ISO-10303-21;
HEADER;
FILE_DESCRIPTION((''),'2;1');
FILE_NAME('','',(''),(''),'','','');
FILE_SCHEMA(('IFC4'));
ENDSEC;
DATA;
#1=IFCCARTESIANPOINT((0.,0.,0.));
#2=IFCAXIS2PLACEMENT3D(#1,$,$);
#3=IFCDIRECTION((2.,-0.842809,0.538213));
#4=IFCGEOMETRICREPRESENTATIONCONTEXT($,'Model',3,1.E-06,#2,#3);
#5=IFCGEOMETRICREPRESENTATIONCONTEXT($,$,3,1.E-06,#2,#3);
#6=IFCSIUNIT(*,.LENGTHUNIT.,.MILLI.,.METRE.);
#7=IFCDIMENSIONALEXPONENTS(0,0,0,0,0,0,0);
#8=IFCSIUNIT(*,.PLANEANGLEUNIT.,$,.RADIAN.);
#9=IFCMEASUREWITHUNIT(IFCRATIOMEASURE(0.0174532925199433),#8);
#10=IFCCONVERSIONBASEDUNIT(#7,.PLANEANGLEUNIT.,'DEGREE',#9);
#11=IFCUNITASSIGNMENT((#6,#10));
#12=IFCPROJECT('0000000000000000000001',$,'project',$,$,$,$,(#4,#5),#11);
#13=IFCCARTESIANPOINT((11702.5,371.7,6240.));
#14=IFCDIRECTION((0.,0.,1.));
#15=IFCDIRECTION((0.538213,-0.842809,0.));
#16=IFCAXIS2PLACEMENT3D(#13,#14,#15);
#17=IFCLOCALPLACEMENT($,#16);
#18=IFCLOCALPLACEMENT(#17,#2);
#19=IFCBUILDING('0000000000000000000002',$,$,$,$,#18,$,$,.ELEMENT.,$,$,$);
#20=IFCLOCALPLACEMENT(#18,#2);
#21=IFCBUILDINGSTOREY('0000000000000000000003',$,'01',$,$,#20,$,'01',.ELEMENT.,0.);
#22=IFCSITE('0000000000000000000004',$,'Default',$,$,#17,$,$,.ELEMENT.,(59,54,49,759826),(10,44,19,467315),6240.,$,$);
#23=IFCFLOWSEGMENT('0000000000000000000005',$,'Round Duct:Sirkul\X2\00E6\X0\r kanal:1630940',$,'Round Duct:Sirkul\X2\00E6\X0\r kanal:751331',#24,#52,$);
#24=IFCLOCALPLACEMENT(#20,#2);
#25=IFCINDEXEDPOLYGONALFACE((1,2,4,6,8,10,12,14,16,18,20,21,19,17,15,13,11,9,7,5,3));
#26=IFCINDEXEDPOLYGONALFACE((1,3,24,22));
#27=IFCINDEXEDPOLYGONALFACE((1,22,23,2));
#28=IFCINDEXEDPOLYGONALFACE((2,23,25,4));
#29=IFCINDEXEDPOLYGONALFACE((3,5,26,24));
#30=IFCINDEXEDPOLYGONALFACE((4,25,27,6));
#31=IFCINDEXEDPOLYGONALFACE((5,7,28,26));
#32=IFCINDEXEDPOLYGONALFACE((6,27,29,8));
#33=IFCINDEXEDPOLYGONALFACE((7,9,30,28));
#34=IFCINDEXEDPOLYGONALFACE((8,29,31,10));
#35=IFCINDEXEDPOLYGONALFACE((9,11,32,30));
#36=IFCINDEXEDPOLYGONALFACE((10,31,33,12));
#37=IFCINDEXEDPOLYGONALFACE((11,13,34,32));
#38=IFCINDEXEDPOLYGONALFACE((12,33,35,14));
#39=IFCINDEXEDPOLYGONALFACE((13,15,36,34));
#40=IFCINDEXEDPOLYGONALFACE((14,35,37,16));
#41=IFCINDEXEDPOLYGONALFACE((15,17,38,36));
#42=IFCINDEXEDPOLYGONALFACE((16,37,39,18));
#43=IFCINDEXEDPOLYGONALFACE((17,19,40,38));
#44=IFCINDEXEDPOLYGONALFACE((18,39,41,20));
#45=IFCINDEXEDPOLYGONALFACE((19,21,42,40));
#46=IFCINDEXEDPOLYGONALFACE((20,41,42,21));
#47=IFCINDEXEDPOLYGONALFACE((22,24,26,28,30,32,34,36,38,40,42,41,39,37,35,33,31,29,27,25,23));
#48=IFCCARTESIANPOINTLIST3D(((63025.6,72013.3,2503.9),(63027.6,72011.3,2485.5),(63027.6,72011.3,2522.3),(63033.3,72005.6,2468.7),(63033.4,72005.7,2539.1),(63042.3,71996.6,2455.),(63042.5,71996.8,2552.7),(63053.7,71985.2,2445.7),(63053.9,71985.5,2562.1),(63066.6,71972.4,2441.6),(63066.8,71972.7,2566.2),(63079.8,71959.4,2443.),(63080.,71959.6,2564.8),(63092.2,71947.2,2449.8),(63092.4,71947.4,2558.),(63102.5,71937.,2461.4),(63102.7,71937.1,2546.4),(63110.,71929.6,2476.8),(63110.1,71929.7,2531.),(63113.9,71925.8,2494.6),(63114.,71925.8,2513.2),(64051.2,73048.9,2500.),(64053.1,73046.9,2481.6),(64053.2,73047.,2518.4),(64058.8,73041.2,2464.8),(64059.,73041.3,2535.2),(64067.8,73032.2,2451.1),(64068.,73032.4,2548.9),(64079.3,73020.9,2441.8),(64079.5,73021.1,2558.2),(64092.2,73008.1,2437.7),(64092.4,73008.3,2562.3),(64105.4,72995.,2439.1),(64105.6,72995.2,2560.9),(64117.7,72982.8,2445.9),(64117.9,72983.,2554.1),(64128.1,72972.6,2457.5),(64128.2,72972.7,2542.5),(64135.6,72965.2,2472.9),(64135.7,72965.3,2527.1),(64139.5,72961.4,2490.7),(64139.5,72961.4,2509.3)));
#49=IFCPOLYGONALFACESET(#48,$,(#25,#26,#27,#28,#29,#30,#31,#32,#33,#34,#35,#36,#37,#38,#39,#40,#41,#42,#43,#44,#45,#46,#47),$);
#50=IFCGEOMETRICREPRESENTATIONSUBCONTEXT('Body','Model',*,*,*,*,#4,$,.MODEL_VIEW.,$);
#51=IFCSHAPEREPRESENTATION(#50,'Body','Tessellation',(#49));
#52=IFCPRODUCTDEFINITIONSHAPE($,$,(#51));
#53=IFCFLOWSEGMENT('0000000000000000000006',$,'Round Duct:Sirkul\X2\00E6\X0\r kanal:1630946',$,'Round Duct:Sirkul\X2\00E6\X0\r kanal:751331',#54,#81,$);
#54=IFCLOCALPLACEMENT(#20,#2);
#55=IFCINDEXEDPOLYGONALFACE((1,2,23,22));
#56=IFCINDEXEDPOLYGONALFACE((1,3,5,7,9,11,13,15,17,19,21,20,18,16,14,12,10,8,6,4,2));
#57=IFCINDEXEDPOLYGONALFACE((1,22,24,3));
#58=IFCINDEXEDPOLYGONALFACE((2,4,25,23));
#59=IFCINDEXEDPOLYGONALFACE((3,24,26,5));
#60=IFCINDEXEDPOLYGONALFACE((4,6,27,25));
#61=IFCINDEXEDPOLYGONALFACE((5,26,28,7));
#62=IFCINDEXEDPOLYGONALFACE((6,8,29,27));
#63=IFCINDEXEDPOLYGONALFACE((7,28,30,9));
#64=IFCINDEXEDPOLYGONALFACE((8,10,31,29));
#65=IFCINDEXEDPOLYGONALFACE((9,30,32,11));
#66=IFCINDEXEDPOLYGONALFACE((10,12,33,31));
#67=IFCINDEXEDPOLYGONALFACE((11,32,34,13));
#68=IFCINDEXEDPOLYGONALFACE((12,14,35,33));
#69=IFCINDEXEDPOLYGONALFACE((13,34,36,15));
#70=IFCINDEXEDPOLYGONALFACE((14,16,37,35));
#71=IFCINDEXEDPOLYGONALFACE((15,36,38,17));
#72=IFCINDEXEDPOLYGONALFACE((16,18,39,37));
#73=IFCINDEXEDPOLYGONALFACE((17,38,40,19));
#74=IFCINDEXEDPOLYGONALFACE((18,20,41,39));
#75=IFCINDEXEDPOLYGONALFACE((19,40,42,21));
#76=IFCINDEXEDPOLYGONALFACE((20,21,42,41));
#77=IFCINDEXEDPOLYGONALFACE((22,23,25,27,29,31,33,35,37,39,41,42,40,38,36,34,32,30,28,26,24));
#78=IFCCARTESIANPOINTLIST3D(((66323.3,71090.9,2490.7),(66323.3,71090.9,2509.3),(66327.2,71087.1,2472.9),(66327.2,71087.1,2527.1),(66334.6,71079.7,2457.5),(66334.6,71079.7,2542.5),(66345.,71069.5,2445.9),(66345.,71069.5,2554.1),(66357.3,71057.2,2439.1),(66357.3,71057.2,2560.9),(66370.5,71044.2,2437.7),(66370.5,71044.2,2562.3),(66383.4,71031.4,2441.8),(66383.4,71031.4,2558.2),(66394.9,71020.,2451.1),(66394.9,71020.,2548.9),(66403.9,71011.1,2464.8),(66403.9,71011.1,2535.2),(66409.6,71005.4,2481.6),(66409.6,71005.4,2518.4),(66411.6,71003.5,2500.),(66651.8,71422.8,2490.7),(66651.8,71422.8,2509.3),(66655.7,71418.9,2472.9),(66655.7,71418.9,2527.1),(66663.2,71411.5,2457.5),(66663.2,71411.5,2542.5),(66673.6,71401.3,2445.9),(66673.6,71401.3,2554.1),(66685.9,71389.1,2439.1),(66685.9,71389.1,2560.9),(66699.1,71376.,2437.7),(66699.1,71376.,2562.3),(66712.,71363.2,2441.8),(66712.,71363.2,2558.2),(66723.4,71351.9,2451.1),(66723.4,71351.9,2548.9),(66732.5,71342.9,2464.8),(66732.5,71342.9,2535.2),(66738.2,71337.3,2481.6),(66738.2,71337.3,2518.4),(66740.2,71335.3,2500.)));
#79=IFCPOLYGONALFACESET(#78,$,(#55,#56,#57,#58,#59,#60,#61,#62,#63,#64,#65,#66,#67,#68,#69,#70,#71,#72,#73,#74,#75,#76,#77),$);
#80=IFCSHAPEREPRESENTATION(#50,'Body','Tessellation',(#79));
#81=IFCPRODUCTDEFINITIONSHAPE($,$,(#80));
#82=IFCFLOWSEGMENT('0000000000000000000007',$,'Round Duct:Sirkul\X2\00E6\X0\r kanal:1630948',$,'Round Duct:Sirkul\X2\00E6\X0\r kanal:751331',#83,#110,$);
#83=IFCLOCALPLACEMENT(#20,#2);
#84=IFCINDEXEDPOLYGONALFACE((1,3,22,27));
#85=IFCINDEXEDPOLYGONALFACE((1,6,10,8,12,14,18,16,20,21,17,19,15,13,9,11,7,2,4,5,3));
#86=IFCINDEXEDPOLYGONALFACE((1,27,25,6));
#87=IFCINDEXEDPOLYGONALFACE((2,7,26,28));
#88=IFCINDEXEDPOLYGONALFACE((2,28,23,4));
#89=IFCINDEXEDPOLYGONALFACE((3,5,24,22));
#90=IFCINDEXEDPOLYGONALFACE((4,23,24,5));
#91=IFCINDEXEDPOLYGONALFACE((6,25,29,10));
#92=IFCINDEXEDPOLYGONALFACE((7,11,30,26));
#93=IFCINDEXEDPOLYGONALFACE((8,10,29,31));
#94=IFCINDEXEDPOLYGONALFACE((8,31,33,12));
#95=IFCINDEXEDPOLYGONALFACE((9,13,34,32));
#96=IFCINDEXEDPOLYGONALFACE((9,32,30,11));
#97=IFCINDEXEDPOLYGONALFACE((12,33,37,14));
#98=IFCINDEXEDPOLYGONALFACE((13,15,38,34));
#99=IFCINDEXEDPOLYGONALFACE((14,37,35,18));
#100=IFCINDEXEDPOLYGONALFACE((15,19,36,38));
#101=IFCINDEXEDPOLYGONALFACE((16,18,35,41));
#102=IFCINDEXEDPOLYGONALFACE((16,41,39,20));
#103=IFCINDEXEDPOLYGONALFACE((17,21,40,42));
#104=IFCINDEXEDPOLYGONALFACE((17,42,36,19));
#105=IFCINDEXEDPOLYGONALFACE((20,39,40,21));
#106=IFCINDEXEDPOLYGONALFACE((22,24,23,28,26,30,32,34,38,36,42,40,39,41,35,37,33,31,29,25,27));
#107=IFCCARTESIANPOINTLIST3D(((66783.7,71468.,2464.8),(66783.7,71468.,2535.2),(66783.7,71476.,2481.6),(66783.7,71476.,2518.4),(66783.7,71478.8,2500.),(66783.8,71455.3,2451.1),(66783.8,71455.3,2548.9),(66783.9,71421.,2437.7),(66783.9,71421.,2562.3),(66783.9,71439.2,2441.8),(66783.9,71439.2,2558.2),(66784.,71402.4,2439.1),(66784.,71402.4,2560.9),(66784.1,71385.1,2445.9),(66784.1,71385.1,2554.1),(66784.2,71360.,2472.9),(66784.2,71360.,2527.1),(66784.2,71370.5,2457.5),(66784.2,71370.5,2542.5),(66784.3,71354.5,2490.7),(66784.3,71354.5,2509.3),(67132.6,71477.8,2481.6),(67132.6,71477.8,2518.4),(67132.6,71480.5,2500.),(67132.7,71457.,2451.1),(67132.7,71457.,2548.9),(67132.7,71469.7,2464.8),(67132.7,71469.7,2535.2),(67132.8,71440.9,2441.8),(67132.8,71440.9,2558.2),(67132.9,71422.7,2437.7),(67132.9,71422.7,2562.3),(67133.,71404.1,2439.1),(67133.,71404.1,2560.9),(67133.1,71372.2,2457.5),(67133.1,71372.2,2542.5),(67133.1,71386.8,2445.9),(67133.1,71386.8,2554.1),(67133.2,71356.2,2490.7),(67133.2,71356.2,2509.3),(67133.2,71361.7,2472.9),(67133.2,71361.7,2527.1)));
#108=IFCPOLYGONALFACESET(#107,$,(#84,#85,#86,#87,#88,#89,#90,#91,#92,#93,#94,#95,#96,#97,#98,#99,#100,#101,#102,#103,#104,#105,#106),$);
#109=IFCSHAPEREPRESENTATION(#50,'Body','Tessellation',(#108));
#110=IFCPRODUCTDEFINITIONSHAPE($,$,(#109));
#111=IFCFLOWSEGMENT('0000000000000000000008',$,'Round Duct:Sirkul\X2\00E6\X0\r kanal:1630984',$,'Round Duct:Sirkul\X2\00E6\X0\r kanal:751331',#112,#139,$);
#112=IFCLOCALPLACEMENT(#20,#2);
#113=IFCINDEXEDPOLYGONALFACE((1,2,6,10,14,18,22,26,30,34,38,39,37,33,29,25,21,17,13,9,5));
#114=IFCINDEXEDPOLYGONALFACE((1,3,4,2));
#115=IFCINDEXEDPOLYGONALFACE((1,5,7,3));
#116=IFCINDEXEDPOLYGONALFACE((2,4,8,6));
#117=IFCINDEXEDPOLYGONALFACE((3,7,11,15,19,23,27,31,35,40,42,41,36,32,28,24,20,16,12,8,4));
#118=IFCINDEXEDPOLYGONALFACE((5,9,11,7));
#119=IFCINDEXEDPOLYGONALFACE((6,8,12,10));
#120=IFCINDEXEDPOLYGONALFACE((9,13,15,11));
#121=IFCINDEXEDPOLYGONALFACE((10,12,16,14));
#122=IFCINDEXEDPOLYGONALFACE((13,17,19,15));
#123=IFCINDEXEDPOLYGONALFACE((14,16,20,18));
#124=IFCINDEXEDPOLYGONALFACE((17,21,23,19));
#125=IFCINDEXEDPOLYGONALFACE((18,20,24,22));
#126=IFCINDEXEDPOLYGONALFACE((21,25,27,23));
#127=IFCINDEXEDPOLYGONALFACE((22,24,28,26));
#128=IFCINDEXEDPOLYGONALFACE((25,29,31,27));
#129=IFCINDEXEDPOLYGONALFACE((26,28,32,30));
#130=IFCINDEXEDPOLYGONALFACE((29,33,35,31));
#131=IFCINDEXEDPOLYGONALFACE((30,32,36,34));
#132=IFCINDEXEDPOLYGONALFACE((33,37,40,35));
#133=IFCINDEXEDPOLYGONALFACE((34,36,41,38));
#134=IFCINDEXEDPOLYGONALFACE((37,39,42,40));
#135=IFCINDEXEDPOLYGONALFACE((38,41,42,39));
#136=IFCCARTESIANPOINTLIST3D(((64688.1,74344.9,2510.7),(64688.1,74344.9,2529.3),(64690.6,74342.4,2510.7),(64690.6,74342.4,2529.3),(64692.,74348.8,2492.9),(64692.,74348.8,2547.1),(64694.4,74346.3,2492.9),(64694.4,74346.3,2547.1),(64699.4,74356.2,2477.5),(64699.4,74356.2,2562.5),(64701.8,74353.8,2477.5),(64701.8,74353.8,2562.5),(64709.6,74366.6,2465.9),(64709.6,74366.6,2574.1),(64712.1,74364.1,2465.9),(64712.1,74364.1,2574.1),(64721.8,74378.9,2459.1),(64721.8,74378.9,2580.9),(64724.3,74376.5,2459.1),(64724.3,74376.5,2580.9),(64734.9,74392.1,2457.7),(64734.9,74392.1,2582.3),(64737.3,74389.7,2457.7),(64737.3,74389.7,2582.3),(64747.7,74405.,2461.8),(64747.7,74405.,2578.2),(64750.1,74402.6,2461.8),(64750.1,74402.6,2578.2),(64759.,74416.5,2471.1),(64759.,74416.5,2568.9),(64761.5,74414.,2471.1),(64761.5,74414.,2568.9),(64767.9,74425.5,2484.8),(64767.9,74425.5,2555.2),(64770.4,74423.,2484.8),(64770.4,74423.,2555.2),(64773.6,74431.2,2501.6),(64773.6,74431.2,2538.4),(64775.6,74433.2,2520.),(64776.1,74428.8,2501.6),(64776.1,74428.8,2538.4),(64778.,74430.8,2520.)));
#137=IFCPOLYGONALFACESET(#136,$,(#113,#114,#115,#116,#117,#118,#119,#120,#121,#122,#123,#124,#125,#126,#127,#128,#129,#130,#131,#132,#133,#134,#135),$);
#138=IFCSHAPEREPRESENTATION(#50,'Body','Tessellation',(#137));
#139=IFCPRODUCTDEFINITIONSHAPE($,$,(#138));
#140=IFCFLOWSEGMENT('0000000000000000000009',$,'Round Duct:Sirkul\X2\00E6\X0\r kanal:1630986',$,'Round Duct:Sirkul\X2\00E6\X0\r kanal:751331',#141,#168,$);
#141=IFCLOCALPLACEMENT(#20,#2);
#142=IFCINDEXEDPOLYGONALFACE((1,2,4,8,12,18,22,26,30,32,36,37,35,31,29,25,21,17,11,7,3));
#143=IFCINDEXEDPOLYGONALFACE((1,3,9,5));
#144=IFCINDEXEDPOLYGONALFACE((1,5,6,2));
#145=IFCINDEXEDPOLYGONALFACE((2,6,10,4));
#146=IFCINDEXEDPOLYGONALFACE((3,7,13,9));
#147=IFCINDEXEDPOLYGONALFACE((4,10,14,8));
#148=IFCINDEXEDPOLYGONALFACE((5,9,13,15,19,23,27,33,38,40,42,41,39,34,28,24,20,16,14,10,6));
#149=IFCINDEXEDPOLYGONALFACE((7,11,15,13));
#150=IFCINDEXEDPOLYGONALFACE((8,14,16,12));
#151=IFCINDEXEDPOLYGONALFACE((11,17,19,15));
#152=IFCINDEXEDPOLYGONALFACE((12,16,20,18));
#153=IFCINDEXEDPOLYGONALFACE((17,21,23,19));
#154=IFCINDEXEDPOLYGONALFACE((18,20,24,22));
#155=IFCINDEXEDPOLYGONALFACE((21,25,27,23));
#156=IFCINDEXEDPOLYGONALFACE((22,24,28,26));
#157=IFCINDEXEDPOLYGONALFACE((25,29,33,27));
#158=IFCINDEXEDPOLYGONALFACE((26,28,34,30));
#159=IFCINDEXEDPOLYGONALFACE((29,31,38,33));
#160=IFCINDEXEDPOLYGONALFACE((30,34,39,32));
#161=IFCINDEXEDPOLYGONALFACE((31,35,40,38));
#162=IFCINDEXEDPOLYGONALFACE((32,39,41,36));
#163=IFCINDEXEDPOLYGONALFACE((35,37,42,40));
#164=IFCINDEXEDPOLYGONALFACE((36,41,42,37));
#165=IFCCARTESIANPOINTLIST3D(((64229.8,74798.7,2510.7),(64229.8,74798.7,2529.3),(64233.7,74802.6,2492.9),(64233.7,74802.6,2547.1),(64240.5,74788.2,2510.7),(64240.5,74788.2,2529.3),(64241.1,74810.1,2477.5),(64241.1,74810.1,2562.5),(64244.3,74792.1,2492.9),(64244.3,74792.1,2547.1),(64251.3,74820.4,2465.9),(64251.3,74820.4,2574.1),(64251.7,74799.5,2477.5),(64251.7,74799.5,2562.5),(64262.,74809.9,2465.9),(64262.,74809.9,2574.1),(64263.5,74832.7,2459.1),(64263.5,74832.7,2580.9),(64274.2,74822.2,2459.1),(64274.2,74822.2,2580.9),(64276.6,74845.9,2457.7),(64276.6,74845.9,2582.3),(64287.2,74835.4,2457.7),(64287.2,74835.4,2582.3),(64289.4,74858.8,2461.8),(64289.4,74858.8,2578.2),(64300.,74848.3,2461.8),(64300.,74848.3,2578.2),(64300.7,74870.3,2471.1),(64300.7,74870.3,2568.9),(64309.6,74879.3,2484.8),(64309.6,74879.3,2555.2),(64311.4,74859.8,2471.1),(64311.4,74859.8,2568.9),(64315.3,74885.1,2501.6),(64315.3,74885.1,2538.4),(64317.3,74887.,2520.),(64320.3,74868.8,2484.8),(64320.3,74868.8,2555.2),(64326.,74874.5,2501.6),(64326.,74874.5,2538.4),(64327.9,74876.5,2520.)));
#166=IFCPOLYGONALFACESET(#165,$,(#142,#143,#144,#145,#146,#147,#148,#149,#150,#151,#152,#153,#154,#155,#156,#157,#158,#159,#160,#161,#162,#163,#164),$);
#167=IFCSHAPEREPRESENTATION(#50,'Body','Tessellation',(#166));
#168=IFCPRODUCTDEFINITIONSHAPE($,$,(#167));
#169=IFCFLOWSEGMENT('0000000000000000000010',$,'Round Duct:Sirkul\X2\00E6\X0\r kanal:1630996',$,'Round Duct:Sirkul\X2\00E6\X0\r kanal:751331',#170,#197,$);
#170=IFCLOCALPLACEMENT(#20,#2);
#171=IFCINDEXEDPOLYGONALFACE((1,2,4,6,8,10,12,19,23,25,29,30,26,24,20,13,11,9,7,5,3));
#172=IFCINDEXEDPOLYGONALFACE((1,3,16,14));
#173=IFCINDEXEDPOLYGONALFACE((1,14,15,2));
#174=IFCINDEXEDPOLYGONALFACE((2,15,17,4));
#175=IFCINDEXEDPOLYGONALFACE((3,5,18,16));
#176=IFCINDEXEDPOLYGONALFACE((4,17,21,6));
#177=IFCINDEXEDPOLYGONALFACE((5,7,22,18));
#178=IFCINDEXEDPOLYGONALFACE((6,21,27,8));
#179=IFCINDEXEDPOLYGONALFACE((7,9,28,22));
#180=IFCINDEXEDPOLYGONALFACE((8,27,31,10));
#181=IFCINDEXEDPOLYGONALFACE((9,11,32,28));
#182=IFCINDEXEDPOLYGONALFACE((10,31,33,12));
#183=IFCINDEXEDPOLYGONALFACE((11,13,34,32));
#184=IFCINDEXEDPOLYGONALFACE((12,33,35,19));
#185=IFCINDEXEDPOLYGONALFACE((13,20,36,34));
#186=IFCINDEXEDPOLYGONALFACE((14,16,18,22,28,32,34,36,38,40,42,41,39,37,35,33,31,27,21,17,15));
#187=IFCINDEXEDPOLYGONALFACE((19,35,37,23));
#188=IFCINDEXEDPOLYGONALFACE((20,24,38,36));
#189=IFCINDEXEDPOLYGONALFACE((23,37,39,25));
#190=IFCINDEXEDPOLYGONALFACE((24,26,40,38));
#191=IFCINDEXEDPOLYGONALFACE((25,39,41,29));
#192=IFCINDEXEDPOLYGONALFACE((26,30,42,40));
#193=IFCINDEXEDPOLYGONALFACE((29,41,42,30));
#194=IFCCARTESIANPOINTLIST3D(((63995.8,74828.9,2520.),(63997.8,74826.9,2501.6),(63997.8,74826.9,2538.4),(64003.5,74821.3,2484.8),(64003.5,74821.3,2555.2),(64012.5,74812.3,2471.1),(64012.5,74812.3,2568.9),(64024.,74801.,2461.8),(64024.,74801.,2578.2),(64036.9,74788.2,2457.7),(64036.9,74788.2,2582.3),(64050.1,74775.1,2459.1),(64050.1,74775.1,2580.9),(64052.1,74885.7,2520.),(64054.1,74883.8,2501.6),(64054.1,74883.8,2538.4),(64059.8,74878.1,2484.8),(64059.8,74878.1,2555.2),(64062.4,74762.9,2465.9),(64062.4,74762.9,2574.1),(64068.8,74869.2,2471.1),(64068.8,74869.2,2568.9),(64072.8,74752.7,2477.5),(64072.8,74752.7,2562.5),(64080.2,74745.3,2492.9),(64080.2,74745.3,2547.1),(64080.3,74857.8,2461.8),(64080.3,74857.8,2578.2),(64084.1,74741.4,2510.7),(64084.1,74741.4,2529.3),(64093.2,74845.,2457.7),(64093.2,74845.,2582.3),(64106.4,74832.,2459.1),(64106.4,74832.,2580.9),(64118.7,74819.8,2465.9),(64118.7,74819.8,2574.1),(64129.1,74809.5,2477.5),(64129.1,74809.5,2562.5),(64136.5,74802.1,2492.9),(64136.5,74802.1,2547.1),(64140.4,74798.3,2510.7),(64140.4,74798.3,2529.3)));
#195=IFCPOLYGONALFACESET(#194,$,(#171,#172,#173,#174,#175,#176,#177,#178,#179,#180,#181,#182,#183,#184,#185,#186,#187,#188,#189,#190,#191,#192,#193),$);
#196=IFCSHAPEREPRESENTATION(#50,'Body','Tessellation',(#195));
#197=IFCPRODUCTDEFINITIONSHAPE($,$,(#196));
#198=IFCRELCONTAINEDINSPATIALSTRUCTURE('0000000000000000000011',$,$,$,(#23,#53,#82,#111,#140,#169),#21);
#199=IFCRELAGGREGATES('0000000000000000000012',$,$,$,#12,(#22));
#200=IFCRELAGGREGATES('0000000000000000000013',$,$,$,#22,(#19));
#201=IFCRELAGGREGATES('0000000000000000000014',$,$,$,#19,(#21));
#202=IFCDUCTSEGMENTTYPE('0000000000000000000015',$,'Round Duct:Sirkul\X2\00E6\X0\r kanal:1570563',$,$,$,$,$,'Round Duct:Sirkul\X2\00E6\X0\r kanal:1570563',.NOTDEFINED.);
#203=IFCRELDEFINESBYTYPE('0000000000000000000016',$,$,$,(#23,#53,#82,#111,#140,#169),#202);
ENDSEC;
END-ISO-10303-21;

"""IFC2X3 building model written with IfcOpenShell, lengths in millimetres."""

from ifc_helpers import new_model, entity, si_unit, converted_unit, direction, frame, frame_2d, origin, origin_2d_with_axis, place, context, subcontext, project, spatial, circle, extrude, type_object, element, save


model = new_model("IFC2X3")

# Units and contexts
model_context = context("Model", 3, precision=1e-06, world=origin(), true_north=direction((2.0, -0.842809, 0.538213)))
context_of_model = context(None, 3, precision=1e-06, world=origin(), true_north=direction((2.0, -0.842809, 0.538213)))
body_context = subcontext(model_context, "Body", "Model", "MODEL_VIEW")
ifc_project = project(units=[si_unit("LENGTHUNIT", "METRE", prefix="MILLI"), converted_unit("PLANEANGLEUNIT", "DEGREE", entity("IfcRatioMeasure", 0.0174532925199433), si_unit("PLANEANGLEUNIT", "RADIAN"), dimensions=[0, 0, 0, 0, 0, 0, 0])], contexts=[model_context, context_of_model])

# Site, building, storey
site_placement = place(None, frame((11702.5, 371.7, 6240.0), z_axis=(0.0, 0.0, 1.0), x_axis=(0.538213, -0.842809, 0.0)))
site = spatial("IfcSite", under=ifc_project, at=site_placement, Name="Default", CompositionType="ELEMENT", RefLatitude=(59, 54, 49, 759826), RefLongitude=(10, 44, 19, 467315), RefElevation=6240.0)
building_placement = place(site_placement, origin())
building = spatial("IfcBuilding", under=site, at=building_placement, CompositionType="ELEMENT")
storey_placement = place(building_placement, origin())
storey = spatial("IfcBuildingStorey", under=building, at=storey_placement, Name="01", LongName="01", CompositionType="ELEMENT", Elevation=0.0)

# Flow segments
duct_segment_type = type_object("IfcDuctSegmentType", Name="Round Duct:Sirkulær kanal:1570563", ElementType="Round Duct:Sirkulær kanal:1570563", PredefinedType="NOTDEFINED")
flow_segment_1_placement = place(storey_placement, origin())
element("IfcFlowSegment", 1, at=flow_segment_1_placement, inside=storey, type_object=duct_segment_type, Name="Round Duct:Sirkulær kanal:1630940", ObjectType="Round Duct:Sirkulær kanal:751331", context=body_context, shape_type="SweptSolid", body=[
    extrude(circle(Radius=62.5, at=origin_2d_with_axis()), frame((63070.1, 71969.3, 2503.9), z_axis=(0.703639, 0.710553, -0.002666), x_axis=(-0.710555, 0.703642, 0.0)), (0.0, 0.0, 1.0), 1457.5),
])
flow_segment_2_placement = place(storey_placement, origin())
element("IfcFlowSegment", 2, at=flow_segment_2_placement, inside=storey, type_object=duct_segment_type, Name="Round Duct:Sirkulær kanal:1630946", ObjectType="Round Duct:Sirkulær kanal:751331", context=body_context, shape_type="SweptSolid", body=[
    extrude(circle(Radius=62.5, at=origin_2d_with_axis()), frame((66367.2, 71047.5, 2500.0), z_axis=(0.703643, 0.710554, 0.0), x_axis=(0.710554, -0.703643, 0.0)), (0.0, 0.0, 1.0), 467.0),
])
flow_segment_3_placement = place(storey_placement, origin())
element("IfcFlowSegment", 3, at=flow_segment_3_placement, inside=storey, type_object=duct_segment_type, Name="Round Duct:Sirkulær kanal:1630948", ObjectType="Round Duct:Sirkulær kanal:751331", context=body_context, shape_type="SweptSolid", body=[
    extrude(circle(Radius=62.5, at=frame_2d((0.0, 0.0), x_axis=(1.0, 0.0))), frame((66784.0, 71416.3, 2500.0), z_axis=(0.999988, 0.004887, 0.0), x_axis=(-0.004887, 0.999988, 0.0)), (0.0, 0.0, 1.0), 349.0),
])
flow_segment_4_placement = place(storey_placement, origin())
element("IfcFlowSegment", 4, at=flow_segment_4_placement, inside=storey, type_object=duct_segment_type, Name="Round Duct:Sirkulær kanal:1630984", ObjectType="Round Duct:Sirkulær kanal:751331", context=body_context, shape_type="SweptSolid", body=[
    extrude(circle(Radius=62.5, at=origin_2d_with_axis()), frame((64731.6, 74388.8, 2520.0), z_axis=(0.710554, -0.703643, 0.0), x_axis=(0.703643, 0.710554, 0.0)), (0.0, 0.0, 1.0), 3.4),
])
flow_segment_5_placement = place(storey_placement, origin())
element("IfcFlowSegment", 5, at=flow_segment_5_placement, inside=storey, type_object=duct_segment_type, Name="Round Duct:Sirkulær kanal:1630986", ObjectType="Round Duct:Sirkulær kanal:751331", context=body_context, shape_type="SweptSolid", body=[
    extrude(circle(Radius=62.5, at=origin_2d_with_axis()), frame((64284.0, 74832.1, 2520.0), z_axis=(-0.710554, 0.703643, 0.0), x_axis=(0.703643, 0.710554, 0.0)), (0.0, 0.0, 1.0), 15.0),
])
flow_segment_6_placement = place(storey_placement, origin())
element("IfcFlowSegment", 6, at=flow_segment_6_placement, inside=storey, type_object=duct_segment_type, Name="Round Duct:Sirkulær kanal:1630996", ObjectType="Round Duct:Sirkulær kanal:751331", context=body_context, shape_type="SweptSolid", body=[
    extrude(circle(Radius=62.5, at=origin_2d_with_axis()), frame((64040.2, 74784.9, 2520.0), z_axis=(0.703643, 0.710554, 0.0), x_axis=(-0.710554, 0.703643, 0.0)), (0.0, 0.0, 1.0), 80.0),
])

save(model, "model.ifc")
